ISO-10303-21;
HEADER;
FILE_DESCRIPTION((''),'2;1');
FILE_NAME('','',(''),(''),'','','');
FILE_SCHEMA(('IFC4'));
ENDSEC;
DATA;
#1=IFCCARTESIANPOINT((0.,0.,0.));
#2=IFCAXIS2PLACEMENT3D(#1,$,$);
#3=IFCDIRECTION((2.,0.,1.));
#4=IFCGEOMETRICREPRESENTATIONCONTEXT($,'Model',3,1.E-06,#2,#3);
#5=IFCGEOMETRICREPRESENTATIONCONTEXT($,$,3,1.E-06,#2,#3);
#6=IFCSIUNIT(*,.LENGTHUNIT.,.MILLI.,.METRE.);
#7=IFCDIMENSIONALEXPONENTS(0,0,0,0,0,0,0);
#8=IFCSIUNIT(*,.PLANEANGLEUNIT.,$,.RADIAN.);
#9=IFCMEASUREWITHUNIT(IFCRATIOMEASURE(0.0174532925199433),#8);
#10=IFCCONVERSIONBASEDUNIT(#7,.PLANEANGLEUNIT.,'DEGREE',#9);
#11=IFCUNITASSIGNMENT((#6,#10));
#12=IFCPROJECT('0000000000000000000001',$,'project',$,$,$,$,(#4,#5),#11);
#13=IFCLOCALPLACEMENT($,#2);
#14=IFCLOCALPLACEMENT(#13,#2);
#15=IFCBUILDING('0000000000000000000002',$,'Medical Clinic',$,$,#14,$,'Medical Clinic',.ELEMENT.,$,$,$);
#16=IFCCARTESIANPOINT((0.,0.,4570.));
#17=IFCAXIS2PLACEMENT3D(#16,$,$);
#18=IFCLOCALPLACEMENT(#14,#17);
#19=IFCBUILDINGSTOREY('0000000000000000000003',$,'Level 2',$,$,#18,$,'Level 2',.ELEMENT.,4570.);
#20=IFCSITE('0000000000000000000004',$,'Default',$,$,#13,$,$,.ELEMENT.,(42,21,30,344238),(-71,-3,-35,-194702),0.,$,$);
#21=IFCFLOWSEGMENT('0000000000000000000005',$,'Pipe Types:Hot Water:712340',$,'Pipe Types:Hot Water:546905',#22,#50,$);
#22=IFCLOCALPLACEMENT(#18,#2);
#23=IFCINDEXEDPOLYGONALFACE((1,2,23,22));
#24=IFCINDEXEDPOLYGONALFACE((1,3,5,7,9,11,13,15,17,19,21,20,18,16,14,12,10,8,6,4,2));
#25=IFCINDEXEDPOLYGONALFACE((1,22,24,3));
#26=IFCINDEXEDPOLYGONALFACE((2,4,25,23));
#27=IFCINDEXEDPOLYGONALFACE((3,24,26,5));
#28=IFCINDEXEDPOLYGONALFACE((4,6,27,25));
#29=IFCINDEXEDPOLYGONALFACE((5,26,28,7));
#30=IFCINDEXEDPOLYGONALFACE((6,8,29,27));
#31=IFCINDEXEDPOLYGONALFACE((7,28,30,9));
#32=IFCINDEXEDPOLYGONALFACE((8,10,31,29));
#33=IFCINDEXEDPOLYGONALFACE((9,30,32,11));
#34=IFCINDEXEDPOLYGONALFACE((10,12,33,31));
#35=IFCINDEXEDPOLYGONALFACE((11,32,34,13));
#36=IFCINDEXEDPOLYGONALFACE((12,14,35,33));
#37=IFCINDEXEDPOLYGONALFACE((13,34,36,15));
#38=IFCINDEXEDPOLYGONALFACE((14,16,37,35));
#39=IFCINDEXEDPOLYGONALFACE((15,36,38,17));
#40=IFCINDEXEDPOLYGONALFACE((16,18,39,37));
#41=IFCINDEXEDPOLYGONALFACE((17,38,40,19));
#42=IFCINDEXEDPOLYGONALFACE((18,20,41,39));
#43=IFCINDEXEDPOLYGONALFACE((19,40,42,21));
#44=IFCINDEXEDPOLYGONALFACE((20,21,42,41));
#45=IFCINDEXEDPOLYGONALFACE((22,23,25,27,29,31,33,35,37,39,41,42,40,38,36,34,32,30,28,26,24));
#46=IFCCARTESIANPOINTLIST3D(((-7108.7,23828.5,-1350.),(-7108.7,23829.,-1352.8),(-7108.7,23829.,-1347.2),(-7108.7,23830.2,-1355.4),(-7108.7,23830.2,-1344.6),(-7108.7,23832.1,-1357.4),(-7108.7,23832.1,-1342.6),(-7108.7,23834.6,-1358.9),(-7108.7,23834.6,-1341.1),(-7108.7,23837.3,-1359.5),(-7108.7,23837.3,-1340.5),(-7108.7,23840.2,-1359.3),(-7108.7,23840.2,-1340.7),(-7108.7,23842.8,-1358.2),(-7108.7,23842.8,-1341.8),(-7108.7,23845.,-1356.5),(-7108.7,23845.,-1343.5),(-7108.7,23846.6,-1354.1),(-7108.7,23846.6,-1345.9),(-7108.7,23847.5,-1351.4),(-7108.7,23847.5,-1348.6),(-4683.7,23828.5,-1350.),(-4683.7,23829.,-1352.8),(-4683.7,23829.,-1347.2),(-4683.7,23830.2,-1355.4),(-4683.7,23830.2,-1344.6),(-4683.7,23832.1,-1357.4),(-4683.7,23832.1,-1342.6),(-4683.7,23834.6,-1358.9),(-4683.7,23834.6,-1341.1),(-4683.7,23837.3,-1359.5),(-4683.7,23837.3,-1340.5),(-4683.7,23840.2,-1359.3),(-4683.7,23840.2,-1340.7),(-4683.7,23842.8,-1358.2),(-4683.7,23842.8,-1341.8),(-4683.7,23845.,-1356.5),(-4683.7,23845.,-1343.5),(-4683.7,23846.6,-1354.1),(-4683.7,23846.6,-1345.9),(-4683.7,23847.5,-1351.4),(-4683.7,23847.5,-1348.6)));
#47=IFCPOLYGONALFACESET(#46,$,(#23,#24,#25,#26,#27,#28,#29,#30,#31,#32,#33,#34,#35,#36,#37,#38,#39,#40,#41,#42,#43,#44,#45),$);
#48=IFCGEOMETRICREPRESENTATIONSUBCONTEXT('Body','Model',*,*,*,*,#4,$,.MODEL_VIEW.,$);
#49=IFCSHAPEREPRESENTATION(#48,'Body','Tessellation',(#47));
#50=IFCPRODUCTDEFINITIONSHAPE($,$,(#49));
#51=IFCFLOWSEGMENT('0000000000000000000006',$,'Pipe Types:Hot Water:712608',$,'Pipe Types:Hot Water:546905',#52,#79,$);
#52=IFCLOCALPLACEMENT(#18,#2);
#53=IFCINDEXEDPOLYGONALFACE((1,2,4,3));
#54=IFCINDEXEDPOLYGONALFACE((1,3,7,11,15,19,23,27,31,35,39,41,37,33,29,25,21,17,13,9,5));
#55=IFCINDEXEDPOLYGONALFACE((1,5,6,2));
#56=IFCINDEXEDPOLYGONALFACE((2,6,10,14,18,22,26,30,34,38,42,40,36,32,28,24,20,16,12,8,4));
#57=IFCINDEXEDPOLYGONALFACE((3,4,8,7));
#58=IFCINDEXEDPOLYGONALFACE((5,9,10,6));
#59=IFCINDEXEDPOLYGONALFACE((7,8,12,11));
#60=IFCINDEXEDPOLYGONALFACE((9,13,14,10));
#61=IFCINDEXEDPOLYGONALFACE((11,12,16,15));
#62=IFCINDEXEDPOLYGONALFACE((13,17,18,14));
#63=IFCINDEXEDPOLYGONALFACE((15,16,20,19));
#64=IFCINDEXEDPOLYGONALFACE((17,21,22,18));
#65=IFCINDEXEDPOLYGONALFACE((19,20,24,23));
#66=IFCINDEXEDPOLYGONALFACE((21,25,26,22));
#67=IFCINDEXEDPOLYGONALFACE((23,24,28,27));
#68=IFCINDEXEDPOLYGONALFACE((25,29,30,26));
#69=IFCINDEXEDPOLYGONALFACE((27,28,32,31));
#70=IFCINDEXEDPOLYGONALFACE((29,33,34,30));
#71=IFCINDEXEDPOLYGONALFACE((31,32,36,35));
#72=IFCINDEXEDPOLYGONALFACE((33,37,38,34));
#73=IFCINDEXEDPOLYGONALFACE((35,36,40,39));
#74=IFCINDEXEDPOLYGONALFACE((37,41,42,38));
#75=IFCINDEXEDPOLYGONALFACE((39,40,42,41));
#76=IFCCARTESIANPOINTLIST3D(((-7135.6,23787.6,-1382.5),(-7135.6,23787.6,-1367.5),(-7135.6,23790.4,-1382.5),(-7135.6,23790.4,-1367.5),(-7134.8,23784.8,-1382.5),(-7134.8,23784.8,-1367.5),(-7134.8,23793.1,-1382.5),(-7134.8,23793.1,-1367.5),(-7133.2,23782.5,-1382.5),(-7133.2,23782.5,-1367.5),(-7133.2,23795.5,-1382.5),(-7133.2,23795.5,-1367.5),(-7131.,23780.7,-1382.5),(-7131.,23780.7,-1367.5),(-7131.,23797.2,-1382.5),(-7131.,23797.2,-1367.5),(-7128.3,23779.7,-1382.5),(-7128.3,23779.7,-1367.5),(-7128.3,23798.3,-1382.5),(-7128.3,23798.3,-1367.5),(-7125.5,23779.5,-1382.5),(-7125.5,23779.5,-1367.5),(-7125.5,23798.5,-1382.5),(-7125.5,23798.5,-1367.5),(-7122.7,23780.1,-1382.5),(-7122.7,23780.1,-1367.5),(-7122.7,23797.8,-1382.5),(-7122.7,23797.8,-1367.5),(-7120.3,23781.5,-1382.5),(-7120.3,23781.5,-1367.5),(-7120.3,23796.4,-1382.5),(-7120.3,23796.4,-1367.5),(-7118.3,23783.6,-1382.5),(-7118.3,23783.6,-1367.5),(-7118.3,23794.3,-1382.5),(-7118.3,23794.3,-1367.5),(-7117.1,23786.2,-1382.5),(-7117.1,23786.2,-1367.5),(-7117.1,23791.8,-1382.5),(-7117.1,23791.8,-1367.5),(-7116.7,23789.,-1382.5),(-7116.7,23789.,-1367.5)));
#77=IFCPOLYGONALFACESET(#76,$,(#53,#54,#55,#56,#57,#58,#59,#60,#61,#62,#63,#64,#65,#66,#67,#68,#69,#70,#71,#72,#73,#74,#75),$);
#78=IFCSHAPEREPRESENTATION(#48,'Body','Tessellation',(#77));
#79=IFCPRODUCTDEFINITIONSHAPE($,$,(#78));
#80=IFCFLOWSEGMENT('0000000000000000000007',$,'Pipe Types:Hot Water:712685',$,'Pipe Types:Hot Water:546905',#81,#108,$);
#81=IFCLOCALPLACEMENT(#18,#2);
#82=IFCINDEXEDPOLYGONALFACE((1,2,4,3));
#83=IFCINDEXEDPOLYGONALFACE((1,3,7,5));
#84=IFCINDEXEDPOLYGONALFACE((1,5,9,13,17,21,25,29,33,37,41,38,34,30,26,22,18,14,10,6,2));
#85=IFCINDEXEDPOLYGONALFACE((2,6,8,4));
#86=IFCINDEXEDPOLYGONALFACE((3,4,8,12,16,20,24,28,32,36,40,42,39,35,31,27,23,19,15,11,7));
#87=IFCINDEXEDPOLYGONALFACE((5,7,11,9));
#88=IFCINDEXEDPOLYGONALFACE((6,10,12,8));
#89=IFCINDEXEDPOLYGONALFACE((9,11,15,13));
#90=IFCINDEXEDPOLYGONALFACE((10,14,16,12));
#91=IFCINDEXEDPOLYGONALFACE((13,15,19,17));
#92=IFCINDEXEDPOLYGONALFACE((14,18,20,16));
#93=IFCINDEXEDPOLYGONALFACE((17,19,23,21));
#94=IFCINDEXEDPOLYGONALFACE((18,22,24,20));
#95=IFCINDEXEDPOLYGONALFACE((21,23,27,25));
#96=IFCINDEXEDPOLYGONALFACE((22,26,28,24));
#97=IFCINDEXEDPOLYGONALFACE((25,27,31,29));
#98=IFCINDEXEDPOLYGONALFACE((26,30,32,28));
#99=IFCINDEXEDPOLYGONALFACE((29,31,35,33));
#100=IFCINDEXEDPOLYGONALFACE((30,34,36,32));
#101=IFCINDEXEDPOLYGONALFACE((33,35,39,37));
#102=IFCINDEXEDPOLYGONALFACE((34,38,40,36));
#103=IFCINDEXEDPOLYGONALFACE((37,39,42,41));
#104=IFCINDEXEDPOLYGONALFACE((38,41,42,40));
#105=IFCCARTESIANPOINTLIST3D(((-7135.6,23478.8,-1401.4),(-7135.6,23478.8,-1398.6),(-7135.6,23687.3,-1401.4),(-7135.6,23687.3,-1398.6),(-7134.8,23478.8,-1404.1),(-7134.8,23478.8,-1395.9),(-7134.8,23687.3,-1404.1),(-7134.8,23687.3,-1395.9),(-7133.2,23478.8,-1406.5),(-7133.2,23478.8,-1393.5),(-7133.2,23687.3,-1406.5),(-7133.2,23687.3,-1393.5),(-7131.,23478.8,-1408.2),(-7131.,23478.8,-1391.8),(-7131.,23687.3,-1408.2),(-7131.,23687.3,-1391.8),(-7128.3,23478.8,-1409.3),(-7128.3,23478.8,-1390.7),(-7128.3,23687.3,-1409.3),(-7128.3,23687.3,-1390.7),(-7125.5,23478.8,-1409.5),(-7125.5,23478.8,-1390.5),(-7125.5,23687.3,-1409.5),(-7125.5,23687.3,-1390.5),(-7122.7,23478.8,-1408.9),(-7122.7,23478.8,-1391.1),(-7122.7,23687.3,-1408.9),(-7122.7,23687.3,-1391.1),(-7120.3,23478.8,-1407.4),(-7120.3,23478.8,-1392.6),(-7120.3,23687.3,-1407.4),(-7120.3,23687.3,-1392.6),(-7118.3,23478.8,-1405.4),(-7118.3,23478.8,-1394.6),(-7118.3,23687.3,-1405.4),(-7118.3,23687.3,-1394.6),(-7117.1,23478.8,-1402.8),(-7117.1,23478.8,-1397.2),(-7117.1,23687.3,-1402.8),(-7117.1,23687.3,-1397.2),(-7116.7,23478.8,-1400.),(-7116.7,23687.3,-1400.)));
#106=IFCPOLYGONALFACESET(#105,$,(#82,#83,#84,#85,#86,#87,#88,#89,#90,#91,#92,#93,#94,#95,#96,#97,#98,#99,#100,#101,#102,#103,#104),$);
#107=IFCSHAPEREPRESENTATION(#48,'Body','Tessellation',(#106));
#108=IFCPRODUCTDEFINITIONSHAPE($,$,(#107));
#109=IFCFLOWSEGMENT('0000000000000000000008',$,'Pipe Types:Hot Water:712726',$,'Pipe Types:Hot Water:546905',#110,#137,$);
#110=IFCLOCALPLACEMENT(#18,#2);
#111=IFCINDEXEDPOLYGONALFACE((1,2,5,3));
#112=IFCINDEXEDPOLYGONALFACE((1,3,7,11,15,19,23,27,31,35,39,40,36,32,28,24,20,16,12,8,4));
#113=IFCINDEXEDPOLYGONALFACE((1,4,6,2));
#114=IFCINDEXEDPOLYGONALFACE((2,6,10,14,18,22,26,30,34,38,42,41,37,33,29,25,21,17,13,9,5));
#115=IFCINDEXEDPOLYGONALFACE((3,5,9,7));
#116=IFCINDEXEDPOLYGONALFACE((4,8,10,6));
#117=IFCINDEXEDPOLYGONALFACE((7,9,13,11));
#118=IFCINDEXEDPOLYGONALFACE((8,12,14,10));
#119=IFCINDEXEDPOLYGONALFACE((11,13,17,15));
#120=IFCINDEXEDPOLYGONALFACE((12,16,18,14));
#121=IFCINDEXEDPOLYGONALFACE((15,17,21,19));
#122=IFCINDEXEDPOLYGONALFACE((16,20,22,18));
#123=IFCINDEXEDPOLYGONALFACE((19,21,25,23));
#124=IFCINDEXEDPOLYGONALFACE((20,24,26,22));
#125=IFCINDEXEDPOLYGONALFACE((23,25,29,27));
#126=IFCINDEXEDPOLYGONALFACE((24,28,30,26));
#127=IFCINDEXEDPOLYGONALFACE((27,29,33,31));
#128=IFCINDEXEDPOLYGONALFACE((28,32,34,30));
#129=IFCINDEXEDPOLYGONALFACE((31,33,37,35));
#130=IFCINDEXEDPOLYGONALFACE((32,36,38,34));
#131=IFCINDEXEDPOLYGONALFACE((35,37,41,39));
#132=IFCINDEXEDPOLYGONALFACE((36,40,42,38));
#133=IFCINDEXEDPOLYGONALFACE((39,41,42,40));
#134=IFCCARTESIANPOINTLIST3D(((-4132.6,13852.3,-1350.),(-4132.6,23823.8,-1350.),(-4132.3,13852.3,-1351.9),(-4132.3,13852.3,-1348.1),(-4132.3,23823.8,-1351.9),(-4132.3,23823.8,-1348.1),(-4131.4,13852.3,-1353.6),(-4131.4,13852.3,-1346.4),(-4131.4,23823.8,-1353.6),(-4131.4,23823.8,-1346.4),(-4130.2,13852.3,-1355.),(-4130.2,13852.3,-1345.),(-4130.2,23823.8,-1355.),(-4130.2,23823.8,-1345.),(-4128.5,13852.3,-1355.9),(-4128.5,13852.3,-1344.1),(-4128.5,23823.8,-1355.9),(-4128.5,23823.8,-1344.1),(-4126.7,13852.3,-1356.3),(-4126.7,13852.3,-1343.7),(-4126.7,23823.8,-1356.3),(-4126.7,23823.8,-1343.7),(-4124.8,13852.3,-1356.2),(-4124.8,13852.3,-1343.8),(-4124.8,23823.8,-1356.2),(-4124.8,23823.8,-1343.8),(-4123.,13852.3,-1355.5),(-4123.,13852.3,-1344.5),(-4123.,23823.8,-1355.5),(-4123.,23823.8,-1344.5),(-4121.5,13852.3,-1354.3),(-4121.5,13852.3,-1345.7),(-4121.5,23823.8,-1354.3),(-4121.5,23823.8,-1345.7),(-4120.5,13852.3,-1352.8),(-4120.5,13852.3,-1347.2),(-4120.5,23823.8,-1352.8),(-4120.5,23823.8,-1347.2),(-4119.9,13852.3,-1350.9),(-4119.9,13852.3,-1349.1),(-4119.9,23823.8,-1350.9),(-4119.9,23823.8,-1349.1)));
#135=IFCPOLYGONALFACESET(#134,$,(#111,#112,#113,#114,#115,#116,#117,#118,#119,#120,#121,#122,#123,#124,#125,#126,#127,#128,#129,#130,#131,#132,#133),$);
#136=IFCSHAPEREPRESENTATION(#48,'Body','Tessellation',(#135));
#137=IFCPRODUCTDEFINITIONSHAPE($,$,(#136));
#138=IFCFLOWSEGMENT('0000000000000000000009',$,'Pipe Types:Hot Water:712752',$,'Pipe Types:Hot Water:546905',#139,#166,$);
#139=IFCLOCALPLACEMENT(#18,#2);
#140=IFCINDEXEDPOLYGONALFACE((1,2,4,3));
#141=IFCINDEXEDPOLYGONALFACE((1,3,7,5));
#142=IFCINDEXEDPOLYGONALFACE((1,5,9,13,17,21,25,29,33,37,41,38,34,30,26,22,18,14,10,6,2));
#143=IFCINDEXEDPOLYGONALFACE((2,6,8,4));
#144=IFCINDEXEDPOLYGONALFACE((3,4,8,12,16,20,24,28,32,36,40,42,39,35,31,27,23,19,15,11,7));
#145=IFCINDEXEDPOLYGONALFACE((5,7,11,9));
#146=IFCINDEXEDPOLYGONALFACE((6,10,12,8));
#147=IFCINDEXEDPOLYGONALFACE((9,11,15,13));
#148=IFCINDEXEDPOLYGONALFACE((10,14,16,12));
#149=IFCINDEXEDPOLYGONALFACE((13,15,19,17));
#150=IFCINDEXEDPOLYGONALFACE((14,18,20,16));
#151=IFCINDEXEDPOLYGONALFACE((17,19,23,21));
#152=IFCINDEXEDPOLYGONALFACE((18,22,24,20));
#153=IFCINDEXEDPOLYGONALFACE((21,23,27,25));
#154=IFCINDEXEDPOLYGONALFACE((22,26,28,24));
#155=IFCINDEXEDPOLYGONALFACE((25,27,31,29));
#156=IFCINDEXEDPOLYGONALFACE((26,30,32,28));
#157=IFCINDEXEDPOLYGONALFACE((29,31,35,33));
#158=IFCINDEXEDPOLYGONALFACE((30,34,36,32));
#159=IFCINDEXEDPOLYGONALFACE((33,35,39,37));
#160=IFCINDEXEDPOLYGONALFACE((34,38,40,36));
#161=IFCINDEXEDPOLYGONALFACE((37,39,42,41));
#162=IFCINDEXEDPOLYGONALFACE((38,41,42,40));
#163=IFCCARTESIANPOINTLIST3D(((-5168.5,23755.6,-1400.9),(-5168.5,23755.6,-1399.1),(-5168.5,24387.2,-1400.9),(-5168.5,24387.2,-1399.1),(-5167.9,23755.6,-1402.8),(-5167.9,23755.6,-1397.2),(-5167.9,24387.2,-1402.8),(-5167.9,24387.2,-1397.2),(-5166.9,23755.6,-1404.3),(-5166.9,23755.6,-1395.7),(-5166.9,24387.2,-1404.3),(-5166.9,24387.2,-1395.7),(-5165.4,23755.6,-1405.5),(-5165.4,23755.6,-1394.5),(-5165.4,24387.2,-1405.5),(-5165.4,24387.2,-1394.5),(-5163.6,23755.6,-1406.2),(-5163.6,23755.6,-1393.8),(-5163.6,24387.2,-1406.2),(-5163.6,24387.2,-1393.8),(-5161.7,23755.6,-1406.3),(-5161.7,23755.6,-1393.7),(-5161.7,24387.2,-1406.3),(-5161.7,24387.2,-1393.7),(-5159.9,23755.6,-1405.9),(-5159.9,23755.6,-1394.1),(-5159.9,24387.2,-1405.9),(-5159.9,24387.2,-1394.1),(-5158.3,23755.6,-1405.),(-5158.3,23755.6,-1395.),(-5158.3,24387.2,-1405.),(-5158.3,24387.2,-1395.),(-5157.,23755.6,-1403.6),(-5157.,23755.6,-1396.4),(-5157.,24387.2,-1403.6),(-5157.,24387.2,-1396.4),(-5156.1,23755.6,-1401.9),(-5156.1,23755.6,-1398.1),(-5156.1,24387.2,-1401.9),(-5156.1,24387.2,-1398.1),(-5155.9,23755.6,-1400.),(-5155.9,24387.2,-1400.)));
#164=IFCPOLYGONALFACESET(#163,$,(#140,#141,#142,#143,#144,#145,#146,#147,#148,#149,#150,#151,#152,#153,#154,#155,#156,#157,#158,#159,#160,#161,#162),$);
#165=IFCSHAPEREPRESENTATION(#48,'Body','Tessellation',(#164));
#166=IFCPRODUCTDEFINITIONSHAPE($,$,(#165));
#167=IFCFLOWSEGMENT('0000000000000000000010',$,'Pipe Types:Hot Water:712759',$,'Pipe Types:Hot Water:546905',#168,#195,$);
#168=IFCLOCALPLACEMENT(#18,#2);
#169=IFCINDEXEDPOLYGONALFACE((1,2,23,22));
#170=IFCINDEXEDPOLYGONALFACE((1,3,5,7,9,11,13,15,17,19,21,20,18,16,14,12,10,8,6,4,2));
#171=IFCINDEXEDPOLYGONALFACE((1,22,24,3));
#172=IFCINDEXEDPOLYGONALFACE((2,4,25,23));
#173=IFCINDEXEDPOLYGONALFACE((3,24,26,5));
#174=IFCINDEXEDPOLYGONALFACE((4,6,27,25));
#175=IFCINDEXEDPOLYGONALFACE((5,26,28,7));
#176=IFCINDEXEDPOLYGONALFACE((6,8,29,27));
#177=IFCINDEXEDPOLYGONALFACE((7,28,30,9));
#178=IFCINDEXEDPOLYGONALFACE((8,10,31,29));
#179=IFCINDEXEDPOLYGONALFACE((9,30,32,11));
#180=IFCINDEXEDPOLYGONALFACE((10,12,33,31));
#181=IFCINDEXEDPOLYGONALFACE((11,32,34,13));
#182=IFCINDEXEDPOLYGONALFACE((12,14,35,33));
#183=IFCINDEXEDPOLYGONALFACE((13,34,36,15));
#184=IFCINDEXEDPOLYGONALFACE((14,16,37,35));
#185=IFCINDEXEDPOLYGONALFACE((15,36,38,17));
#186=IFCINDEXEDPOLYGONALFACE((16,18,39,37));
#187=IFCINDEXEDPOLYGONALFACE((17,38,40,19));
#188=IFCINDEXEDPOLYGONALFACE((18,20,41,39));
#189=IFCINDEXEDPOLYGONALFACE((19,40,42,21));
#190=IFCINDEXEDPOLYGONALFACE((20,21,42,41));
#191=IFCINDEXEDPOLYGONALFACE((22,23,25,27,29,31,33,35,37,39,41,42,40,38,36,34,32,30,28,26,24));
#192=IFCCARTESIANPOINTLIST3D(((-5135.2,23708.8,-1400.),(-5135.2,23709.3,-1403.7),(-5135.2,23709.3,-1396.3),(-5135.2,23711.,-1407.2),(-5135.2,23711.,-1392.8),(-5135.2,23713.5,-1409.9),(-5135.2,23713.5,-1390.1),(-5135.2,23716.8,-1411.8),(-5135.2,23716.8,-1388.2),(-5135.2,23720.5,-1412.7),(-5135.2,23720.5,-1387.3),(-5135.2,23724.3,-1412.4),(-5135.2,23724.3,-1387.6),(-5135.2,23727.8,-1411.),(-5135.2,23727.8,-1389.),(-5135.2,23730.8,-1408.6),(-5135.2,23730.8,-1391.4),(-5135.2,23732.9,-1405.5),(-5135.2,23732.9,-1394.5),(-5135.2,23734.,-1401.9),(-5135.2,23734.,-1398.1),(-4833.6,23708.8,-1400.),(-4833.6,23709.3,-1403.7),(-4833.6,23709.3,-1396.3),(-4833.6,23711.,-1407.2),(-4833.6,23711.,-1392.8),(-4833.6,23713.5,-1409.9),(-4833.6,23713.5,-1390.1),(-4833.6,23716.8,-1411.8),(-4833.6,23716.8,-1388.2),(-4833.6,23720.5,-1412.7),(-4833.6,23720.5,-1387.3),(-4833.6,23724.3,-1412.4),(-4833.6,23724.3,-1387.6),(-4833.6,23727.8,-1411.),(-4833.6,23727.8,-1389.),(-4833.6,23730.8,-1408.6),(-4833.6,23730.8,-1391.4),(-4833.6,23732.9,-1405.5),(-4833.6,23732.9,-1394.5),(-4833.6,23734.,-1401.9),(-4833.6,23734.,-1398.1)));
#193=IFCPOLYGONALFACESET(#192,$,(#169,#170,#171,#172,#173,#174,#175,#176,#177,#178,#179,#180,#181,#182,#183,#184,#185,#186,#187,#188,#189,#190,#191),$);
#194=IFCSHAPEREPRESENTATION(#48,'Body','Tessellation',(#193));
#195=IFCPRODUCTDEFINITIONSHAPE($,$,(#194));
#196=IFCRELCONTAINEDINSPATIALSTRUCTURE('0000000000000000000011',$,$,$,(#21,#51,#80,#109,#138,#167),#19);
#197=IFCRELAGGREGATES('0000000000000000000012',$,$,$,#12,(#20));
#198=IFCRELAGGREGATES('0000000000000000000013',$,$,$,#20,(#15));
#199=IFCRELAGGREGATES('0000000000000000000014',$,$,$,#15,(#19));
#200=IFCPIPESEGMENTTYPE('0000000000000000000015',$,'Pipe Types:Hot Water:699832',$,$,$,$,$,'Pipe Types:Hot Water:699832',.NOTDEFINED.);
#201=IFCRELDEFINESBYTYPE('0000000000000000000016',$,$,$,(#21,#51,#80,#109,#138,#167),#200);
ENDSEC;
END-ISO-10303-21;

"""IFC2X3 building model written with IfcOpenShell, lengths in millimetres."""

from ifc_helpers import new_model, entity, si_unit, converted_unit, direction, frame, frame_2d, origin, origin_2d_with_axis, place, context, subcontext, project, spatial, circle, extrude, type_object, element, save


model = new_model("IFC2X3")

# Units and contexts
model_context = context("Model", 3, precision=1e-06, world=origin(), true_north=direction((2.0, 0.0, 1.0)))
context_of_model = context(None, 3, precision=1e-06, world=origin(), true_north=direction((2.0, 0.0, 1.0)))
body_context = subcontext(model_context, "Body", "Model", "MODEL_VIEW")
ifc_project = project(units=[si_unit("LENGTHUNIT", "METRE", prefix="MILLI"), converted_unit("PLANEANGLEUNIT", "DEGREE", entity("IfcRatioMeasure", 0.0174532925199433), si_unit("PLANEANGLEUNIT", "RADIAN"), dimensions=[0, 0, 0, 0, 0, 0, 0])], contexts=[model_context, context_of_model])

# Site, building, storey
site_placement = place(None, origin())
site = spatial("IfcSite", under=ifc_project, at=site_placement, Name="Default", CompositionType="ELEMENT", RefLatitude=(42, 21, 30, 344238), RefLongitude=(-71, -3, -35, -194702), RefElevation=0.0)
building_placement = place(site_placement, origin())
building = spatial("IfcBuilding", under=site, at=building_placement, Name="Medical Clinic", LongName="Medical Clinic", CompositionType="ELEMENT")
storey_placement = place(building_placement, frame((0.0, 0.0, 4570.0)))
storey = spatial("IfcBuildingStorey", under=building, at=storey_placement, Name="Level 2", LongName="Level 2", CompositionType="ELEMENT", Elevation=4570.0)

# Flow segments
pipe_segment_type_1 = type_object("IfcPipeSegmentType", Name="Pipe Types:Hot Water:699832", ElementType="Pipe Types:Hot Water:699832", PredefinedType="NOTDEFINED")
flow_segment_1_placement = place(storey_placement, origin())
element("IfcFlowSegment", 1, at=flow_segment_1_placement, inside=storey, type_object=pipe_segment_type_1, Name="Pipe Types:Hot Water:712340", ObjectType="Pipe Types:Hot Water:546905", context=body_context, shape_type="SweptSolid", body=[
    extrude(circle(Radius=9.5, at=origin_2d_with_axis()), frame((-7108.7, 23838.1, -1350.0), z_axis=(1.0, 0.0, 0.0), x_axis=(0.0, -1.0, 0.0)), (0.0, 0.0, 1.0), 2425.1),
])
flow_segment_2_placement = place(storey_placement, origin())
element("IfcFlowSegment", 2, at=flow_segment_2_placement, inside=storey, type_object=pipe_segment_type_1, Name="Pipe Types:Hot Water:712608", ObjectType="Pipe Types:Hot Water:546905", context=body_context, shape_type="SweptSolid", body=[
    extrude(circle(Radius=9.5, at=origin_2d_with_axis()), frame((-7126.2, 23789.0, -1382.5)), (0.0, 0.0, 1.0), 15.1),
])
flow_segment_3_placement = place(storey_placement, origin())
element("IfcFlowSegment", 3, at=flow_segment_3_placement, inside=storey, type_object=pipe_segment_type_1, Name="Pipe Types:Hot Water:712685", ObjectType="Pipe Types:Hot Water:546905", context=body_context, shape_type="SweptSolid", body=[
    extrude(circle(Radius=9.5, at=origin_2d_with_axis()), frame((-7126.2, 23478.8, -1400.0), z_axis=(0.0, 1.0, 0.0), x_axis=(1.0, 0.0, 0.0)), (0.0, 0.0, 1.0), 208.5),
])
flow_segment_4_placement = place(storey_placement, origin())
element("IfcFlowSegment", 4, at=flow_segment_4_placement, inside=storey, type_object=pipe_segment_type_1, Name="Pipe Types:Hot Water:712726", ObjectType="Pipe Types:Hot Water:546905", context=body_context, shape_type="SweptSolid", body=[
    extrude(circle(Radius=6.3, at=frame_2d((0.0, 0.0), x_axis=(1.0, 0.0))), frame((-4126.2, 13852.3, -1350.0), z_axis=(0.0, 1.0, 0.0), x_axis=(-1.0, 0.0, 0.0)), (0.0, 0.0, 1.0), 9971.4),
])
flow_segment_5_placement = place(storey_placement, origin())
element("IfcFlowSegment", 5, at=flow_segment_5_placement, inside=storey, type_object=pipe_segment_type_1, Name="Pipe Types:Hot Water:712752", ObjectType="Pipe Types:Hot Water:546905", context=body_context, shape_type="SweptSolid", body=[
    extrude(circle(Radius=6.3, at=origin_2d_with_axis()), frame((-5162.2, 23755.6, -1400.0), z_axis=(0.0, 1.0, 0.0), x_axis=(1.0, 0.0, 0.0)), (0.0, 0.0, 1.0), 631.6),
])
flow_segment_6_placement = place(storey_placement, origin())
element("IfcFlowSegment", 6, at=flow_segment_6_placement, inside=storey, type_object=pipe_segment_type_1, Name="Pipe Types:Hot Water:712759", ObjectType="Pipe Types:Hot Water:546905", context=body_context, shape_type="SweptSolid", body=[
    extrude(circle(Radius=12.7, at=origin_2d_with_axis()), frame((-5135.2, 23721.5, -1400.0), z_axis=(1.0, 0.0, 0.0), x_axis=(0.0, -1.0, 0.0)), (0.0, 0.0, 1.0), 301.7),
])

save(model, "model.ifc")
